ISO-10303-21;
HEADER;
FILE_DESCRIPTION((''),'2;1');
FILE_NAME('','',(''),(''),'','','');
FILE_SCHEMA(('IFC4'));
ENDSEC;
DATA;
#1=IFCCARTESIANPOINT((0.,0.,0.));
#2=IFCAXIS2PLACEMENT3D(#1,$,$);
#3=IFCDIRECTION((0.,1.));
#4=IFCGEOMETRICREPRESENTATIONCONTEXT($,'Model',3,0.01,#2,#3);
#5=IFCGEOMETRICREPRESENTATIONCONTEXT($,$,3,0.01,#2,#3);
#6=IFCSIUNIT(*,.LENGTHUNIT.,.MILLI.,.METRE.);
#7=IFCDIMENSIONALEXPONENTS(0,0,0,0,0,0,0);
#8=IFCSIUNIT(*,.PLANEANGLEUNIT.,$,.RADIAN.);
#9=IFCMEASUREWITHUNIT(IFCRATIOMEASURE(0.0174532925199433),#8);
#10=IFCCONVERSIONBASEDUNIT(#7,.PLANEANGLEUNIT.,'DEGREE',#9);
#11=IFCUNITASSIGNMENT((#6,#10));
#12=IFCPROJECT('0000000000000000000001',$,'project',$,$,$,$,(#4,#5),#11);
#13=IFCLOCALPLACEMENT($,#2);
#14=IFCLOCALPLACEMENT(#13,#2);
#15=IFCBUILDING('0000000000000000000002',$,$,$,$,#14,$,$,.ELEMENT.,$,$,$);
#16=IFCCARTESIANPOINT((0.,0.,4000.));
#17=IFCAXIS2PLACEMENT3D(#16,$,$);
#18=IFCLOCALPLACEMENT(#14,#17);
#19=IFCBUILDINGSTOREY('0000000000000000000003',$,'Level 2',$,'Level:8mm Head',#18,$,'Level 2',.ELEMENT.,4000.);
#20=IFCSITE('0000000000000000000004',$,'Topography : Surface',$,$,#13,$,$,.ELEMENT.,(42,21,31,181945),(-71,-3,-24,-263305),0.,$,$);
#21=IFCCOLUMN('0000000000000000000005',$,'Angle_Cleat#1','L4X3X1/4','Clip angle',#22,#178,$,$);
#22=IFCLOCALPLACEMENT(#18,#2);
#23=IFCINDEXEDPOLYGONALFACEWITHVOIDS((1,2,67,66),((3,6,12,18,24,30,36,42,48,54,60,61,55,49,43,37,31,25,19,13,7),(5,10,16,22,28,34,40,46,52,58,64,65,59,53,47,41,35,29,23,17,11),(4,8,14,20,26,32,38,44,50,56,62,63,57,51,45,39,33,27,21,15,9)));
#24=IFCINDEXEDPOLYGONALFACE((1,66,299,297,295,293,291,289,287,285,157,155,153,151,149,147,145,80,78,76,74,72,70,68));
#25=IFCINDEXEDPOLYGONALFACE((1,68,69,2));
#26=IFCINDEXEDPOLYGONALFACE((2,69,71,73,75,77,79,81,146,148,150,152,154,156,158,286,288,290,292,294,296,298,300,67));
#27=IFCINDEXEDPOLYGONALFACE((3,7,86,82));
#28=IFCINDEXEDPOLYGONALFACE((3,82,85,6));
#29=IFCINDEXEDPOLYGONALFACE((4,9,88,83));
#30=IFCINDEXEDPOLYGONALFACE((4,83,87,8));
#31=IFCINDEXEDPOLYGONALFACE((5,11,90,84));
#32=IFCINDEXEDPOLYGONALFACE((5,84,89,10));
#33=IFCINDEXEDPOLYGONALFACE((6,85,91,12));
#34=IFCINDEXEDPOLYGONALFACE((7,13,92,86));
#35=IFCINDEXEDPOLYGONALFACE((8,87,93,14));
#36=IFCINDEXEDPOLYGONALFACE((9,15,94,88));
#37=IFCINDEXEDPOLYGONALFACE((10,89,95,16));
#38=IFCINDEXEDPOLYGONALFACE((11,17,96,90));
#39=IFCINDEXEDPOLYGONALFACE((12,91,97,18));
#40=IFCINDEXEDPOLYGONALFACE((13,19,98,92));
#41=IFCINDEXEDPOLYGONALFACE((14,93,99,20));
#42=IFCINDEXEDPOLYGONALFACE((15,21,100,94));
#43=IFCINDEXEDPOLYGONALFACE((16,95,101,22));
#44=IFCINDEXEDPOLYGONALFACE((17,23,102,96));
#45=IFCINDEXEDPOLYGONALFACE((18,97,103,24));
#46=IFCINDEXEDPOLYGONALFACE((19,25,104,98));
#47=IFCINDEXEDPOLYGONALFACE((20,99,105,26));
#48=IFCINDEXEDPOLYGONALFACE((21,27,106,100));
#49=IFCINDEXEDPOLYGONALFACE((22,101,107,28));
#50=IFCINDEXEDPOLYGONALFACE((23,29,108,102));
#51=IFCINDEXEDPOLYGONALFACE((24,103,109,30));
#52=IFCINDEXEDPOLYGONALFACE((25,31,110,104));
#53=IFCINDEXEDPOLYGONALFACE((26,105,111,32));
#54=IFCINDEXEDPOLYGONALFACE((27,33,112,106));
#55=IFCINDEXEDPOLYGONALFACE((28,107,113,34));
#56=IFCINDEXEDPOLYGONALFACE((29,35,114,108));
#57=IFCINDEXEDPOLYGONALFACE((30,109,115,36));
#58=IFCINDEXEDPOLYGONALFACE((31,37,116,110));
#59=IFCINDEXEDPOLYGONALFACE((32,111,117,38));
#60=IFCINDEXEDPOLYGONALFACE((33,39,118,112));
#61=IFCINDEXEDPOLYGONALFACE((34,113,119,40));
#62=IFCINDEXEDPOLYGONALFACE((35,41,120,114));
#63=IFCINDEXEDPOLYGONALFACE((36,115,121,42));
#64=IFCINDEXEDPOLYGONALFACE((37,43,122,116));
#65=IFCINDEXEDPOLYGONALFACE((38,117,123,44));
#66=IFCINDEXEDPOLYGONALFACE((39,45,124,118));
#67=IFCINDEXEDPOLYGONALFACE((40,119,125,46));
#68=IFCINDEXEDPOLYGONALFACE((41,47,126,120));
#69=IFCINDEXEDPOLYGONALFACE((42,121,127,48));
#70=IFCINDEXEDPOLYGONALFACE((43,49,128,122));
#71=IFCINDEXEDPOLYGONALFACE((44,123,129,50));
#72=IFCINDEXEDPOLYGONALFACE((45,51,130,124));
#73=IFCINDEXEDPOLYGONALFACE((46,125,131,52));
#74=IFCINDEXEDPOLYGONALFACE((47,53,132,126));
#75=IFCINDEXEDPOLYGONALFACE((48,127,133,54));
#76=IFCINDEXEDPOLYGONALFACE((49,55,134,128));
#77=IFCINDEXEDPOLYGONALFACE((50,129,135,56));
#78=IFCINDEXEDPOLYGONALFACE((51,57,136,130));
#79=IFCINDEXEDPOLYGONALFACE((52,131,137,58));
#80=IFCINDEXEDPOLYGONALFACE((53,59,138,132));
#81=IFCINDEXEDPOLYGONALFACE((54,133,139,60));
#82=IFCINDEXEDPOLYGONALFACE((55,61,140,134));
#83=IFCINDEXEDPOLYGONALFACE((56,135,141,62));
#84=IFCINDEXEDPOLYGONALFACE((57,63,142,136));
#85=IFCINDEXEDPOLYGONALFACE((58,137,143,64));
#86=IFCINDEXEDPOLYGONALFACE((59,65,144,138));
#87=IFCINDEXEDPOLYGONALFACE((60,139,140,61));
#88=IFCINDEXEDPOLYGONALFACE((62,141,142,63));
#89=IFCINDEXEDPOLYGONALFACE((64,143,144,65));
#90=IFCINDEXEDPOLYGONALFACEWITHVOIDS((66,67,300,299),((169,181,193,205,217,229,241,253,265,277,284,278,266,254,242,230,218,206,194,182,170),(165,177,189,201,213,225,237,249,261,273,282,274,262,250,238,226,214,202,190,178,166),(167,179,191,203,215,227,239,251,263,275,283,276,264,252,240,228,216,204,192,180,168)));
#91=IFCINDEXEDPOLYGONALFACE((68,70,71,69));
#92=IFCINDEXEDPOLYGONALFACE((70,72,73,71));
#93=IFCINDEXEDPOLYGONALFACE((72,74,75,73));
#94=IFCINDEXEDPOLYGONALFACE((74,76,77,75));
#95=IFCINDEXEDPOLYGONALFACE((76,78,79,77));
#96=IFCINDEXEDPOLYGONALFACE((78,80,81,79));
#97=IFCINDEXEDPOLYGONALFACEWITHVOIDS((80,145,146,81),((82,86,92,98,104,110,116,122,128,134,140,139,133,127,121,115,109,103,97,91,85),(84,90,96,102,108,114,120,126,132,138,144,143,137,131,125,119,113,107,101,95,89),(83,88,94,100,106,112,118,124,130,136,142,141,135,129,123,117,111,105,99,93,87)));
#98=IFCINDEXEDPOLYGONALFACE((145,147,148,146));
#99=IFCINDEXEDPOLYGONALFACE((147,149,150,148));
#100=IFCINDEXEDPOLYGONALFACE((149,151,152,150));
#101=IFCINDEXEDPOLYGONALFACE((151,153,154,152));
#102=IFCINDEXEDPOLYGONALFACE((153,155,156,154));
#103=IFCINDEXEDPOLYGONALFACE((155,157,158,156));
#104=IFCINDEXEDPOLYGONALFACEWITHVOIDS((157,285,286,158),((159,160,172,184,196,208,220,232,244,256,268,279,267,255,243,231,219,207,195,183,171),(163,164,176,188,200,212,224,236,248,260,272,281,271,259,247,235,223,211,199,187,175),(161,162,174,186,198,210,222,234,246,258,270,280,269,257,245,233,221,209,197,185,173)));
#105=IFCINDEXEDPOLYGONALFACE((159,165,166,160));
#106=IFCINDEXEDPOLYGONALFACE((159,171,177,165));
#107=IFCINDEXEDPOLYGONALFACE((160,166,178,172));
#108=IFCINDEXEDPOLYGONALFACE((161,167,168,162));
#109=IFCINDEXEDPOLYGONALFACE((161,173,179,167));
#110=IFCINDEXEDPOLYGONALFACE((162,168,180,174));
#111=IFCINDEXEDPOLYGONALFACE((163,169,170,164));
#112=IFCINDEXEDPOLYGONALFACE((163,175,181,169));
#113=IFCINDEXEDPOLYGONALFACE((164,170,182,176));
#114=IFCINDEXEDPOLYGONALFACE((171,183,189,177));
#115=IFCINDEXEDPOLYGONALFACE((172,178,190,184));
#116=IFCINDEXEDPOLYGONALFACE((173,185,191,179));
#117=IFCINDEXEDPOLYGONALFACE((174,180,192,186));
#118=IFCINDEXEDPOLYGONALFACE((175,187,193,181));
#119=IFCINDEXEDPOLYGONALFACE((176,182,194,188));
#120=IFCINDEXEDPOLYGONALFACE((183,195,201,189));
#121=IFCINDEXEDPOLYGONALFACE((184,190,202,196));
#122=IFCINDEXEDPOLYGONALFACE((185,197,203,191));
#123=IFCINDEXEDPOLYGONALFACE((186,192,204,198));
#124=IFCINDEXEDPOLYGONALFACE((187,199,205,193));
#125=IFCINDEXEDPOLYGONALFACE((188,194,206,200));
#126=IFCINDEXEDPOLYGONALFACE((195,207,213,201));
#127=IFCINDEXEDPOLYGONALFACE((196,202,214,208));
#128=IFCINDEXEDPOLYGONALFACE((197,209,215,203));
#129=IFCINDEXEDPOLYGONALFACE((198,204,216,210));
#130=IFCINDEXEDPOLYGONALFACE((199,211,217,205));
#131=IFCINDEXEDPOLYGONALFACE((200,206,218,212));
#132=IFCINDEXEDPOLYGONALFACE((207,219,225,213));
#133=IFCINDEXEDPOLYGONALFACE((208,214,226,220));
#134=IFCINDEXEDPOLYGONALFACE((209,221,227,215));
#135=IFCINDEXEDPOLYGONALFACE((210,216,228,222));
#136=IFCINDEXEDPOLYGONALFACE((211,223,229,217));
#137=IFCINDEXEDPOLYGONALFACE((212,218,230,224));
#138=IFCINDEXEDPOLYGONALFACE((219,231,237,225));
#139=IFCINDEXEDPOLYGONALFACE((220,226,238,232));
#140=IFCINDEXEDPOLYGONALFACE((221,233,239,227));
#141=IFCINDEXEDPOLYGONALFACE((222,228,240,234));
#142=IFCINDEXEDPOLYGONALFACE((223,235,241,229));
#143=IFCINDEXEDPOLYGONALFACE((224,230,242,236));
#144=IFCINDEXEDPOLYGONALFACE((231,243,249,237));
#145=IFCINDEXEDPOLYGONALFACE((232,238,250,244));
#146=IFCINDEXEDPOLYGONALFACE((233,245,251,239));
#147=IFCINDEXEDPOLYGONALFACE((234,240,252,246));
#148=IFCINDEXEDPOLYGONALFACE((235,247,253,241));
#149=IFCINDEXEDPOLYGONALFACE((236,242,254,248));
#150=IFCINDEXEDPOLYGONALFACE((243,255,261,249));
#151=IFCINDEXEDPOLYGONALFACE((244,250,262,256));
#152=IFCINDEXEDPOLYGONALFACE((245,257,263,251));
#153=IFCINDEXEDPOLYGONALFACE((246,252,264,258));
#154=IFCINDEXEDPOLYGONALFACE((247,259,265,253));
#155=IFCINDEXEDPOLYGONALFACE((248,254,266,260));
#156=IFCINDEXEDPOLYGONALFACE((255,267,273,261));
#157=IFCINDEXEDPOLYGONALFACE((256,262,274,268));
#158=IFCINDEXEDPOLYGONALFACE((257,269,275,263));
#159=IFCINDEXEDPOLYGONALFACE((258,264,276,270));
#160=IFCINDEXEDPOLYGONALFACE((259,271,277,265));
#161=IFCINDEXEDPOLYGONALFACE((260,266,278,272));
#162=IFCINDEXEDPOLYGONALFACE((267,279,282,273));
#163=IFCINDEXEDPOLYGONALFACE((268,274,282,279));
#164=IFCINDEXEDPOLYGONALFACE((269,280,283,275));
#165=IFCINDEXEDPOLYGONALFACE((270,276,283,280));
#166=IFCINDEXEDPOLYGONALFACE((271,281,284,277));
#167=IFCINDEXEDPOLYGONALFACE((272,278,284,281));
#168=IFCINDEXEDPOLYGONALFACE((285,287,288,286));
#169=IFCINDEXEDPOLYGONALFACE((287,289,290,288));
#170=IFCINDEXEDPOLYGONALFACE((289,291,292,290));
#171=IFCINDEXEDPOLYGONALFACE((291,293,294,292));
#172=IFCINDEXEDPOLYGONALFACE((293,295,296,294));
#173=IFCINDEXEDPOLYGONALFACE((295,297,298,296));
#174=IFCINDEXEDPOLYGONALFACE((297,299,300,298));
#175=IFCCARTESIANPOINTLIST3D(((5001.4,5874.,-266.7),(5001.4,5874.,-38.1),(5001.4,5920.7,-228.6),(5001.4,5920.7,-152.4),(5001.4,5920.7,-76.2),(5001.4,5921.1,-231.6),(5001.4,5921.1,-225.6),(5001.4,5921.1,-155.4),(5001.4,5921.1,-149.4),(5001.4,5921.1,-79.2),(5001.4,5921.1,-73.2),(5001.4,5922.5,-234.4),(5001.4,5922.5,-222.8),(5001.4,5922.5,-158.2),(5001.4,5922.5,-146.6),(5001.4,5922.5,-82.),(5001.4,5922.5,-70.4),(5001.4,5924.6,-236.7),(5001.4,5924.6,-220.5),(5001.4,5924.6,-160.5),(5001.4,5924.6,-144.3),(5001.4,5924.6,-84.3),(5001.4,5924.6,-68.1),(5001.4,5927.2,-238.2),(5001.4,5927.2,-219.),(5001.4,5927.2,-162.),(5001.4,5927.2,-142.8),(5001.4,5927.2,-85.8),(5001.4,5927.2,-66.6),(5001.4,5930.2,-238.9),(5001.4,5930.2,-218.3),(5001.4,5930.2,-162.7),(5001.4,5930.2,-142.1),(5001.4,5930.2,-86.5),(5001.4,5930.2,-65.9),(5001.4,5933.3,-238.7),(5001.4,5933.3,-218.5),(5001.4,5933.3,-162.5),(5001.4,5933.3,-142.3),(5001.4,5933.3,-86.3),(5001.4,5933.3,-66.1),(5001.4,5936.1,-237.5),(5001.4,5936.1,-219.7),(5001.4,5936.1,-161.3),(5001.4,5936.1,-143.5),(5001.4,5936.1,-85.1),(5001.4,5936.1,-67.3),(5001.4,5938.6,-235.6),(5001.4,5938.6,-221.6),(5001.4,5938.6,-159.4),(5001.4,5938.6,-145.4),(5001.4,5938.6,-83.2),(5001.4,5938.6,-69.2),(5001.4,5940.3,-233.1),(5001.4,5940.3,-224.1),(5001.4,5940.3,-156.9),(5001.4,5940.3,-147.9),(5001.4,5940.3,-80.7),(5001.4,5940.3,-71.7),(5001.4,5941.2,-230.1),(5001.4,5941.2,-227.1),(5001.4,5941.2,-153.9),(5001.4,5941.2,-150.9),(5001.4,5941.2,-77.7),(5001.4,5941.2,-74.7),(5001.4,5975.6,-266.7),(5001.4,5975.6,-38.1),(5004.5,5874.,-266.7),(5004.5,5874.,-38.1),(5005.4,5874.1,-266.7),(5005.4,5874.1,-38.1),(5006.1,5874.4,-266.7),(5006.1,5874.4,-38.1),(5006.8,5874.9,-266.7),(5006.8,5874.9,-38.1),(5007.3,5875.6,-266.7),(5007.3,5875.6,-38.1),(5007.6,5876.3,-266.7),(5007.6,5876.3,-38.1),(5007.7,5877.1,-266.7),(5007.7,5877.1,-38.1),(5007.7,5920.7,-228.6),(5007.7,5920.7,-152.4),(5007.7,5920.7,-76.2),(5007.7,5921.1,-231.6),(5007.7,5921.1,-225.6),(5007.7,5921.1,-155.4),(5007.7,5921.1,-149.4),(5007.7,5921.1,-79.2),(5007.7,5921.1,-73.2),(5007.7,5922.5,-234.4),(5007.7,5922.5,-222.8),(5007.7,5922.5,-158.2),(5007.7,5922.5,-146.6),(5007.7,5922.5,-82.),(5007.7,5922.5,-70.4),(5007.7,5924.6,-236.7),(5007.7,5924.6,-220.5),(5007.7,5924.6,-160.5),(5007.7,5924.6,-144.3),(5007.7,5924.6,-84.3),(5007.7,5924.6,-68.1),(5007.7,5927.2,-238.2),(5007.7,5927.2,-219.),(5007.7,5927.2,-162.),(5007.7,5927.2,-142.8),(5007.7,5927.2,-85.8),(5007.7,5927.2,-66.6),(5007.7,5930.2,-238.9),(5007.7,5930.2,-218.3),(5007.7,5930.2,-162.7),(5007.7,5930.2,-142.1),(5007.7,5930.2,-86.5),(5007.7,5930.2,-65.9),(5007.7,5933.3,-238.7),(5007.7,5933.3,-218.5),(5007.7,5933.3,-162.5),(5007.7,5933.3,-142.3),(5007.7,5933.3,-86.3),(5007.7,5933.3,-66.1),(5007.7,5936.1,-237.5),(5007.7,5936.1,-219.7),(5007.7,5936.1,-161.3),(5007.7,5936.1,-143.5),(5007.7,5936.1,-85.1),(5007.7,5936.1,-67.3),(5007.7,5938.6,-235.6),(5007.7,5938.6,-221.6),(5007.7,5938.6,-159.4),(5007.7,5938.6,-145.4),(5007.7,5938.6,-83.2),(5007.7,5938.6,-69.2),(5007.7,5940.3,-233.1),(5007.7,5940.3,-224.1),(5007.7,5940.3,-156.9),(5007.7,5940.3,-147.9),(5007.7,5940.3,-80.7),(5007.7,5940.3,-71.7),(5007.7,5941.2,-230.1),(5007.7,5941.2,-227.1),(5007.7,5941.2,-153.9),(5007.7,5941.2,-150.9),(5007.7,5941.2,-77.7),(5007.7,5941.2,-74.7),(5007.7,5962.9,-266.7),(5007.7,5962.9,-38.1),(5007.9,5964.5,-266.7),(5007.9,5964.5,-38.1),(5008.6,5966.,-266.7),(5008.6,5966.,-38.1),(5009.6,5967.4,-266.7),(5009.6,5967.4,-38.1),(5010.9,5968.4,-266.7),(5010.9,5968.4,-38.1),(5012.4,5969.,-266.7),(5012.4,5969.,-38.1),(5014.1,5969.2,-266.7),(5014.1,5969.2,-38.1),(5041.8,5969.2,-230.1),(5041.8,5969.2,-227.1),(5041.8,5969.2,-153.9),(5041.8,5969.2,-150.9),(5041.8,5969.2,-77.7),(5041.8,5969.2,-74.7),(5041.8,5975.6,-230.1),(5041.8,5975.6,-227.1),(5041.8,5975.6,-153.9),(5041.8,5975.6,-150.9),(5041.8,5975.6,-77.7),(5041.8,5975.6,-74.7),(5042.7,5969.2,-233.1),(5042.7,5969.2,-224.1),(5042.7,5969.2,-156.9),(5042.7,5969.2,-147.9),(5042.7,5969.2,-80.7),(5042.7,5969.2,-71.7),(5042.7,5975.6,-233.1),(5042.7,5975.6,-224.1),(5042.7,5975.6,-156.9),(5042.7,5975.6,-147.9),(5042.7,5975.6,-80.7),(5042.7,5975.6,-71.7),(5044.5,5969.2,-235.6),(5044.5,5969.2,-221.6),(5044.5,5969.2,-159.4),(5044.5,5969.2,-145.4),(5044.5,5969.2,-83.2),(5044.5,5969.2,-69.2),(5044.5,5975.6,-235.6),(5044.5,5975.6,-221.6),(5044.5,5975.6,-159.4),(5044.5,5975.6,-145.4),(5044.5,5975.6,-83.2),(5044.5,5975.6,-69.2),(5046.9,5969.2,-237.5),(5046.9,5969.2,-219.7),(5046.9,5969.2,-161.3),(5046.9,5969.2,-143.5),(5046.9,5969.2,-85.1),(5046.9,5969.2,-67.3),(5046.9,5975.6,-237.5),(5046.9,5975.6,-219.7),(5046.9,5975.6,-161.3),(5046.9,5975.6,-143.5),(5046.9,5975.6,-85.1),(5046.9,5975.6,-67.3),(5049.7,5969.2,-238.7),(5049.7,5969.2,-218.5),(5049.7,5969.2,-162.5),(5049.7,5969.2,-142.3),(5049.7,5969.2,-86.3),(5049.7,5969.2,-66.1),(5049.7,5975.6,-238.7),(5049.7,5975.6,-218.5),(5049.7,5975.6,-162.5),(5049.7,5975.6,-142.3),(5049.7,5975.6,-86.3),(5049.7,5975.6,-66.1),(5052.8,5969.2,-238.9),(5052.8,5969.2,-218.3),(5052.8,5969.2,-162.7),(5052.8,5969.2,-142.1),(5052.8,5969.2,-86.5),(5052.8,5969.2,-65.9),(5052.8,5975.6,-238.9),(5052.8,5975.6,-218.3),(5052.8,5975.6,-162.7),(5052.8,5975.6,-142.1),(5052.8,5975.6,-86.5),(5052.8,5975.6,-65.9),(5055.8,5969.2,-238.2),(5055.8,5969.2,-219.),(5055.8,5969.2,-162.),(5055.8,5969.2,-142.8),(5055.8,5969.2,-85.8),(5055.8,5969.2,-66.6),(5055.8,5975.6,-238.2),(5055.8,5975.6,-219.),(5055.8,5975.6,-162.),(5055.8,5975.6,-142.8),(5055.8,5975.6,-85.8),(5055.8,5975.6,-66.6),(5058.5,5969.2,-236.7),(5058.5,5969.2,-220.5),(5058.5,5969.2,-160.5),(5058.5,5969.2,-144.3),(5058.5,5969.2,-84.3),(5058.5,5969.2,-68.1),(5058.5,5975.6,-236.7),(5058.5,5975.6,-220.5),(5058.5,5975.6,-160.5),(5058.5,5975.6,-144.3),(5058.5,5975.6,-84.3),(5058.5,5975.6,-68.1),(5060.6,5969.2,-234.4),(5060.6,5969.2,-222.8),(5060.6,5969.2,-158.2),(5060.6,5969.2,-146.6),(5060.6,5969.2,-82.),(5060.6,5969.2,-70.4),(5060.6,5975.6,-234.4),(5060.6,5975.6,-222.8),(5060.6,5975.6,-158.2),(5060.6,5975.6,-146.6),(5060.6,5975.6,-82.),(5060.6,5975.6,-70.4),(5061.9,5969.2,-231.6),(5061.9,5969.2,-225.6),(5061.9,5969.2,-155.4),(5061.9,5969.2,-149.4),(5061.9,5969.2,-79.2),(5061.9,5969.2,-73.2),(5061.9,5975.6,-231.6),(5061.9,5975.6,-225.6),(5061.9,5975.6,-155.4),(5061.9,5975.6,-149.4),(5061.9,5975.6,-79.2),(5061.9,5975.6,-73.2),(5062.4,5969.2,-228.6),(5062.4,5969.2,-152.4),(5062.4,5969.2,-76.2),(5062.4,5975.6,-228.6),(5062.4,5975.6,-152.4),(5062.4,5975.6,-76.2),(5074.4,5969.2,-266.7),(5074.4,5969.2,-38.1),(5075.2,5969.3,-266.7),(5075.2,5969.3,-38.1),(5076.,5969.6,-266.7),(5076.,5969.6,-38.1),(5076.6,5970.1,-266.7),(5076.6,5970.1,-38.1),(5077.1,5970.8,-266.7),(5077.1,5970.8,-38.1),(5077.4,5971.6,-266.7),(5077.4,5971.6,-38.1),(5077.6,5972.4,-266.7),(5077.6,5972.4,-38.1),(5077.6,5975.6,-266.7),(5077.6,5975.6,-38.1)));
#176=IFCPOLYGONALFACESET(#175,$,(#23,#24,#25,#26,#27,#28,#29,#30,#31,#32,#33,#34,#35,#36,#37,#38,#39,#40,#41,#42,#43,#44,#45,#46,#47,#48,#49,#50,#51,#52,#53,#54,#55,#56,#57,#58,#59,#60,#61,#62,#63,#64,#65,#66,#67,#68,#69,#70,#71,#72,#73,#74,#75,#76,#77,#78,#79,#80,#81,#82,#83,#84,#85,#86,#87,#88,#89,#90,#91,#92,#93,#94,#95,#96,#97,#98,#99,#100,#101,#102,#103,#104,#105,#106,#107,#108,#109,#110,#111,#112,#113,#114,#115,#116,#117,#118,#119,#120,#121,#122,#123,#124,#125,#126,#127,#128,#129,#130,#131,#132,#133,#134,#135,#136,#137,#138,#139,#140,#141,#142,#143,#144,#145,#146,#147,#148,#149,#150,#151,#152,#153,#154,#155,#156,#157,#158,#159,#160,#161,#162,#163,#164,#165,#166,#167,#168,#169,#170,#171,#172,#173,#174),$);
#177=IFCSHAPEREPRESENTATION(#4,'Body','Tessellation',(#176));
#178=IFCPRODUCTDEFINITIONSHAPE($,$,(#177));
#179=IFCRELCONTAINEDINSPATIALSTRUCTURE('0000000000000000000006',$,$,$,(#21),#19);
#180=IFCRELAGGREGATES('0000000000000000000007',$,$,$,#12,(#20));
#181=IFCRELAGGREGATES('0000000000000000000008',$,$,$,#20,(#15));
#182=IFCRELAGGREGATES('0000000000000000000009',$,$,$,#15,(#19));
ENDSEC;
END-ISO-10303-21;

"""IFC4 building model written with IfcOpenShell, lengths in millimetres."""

from ifc_helpers import new_model, entity, si_unit, converted_unit, direction, frame, frame_2d, origin, origin_2d_with_axis, place, context, project, spatial, circle, l_section, extrude, element, save


model = new_model("IFC4")

# Units and contexts
model_context = context("Model", 3, precision=0.01, world=origin(), true_north=direction((0.0, 1.0)))
context_of_model = context(None, 3, precision=0.01, world=origin(), true_north=direction((0.0, 1.0)))
ifc_project = project(units=[si_unit("LENGTHUNIT", "METRE", prefix="MILLI"), converted_unit("PLANEANGLEUNIT", "DEGREE", entity("IfcRatioMeasure", 0.0174532925199433), si_unit("PLANEANGLEUNIT", "RADIAN"), dimensions=[0, 0, 0, 0, 0, 0, 0])], contexts=[model_context, context_of_model])

# Site, building, storey
site_placement = place(None, origin())
site = spatial("IfcSite", under=ifc_project, at=site_placement, Name="Topography : Surface", CompositionType="ELEMENT", RefLatitude=(42, 21, 31, 181945), RefLongitude=(-71, -3, -24, -263305), RefElevation=0.0)
building_placement = place(site_placement, origin())
building = spatial("IfcBuilding", under=site, at=building_placement, CompositionType="ELEMENT")
storey_placement = place(building_placement, frame((0.0, 0.0, 4000.0)))
storey = spatial("IfcBuildingStorey", under=building, at=storey_placement, Name="Level 2", ObjectType="Level:8mm Head", LongName="Level 2", CompositionType="ELEMENT", Elevation=4000.0)

# Column, openings
column_1_placement = place(storey_placement, frame((5019.6, 5944.4, -266.7), z_axis=(0.0, 0.0, -1.0), x_axis=(1.0, 0.0, 0.0)))
column_1 = element("IfcColumn", 1, at=column_1_placement, inside=storey, Name="Angle_Cleat#1", Description="L4X3X1/4", ObjectType="Clip angle", context=model_context, shape_type="SweptSolid", body=[
    extrude(l_section(Depth=101.6, Width=76.2, Thickness=6.3, FilletRadius=6.3, EdgeRadius=3.2, at=frame_2d((19.8, 19.7))), origin(), (0.0, 0.0, -1.0), 228.6),
])
opening_1_placement = place(column_1_placement, frame((32.4, -31.5, -114.3), z_axis=(0.0, 1.0, 0.0), x_axis=(1.0, 0.0, 0.0)))
element("IfcOpeningElement", 2, at=opening_1_placement, cuts=column_1, ObjectType="Opening", context=model_context, shape_type="SweptSolid", body=[
    extrude(circle(Radius=10.3, at=origin_2d_with_axis()), origin(), (0.0, 0.0, 1.0), 7.3),
])
opening_2_placement = place(column_1_placement, frame((32.4, -31.5, -114.3), z_axis=(0.0, 1.0, 0.0), x_axis=(1.0, 0.0, 0.0)))
element("IfcOpeningElement", 3, at=opening_2_placement, cuts=column_1, ObjectType="Opening", context=model_context, shape_type="SweptSolid", body=[
    extrude(circle(Radius=10.3, at=frame_2d((0.0, 76.2), x_axis=(1.0, 0.0))), origin(), (0.0, 0.0, 1.0), 7.3),
])
opening_3_placement = place(column_1_placement, frame((32.4, -31.5, -114.3), z_axis=(0.0, 1.0, 0.0), x_axis=(1.0, 0.0, 0.0)))
element("IfcOpeningElement", 4, at=opening_3_placement, cuts=column_1, ObjectType="Opening", context=model_context, shape_type="SweptSolid", body=[
    extrude(circle(Radius=10.3, at=frame_2d((0.0, -76.2), x_axis=(1.0, 0.0))), origin(), (0.0, 0.0, 1.0), 7.3),
])
opening_4_placement = place(column_1_placement, frame((-18.9, 13.5, -114.3), z_axis=(1.0, 0.0, 0.0), x_axis=(0.0, 1.0, 0.0)))
element("IfcOpeningElement", 5, at=opening_4_placement, cuts=column_1, ObjectType="Opening", context=model_context, shape_type="SweptSolid", body=[
    extrude(circle(Radius=10.3, at=origin_2d_with_axis()), origin(), (0.0, 0.0, 1.0), 7.3),
])
opening_5_placement = place(column_1_placement, frame((-18.9, 13.5, -114.3), z_axis=(1.0, 0.0, 0.0), x_axis=(0.0, 1.0, 0.0)))
element("IfcOpeningElement", 6, at=opening_5_placement, cuts=column_1, ObjectType="Opening", context=model_context, shape_type="SweptSolid", body=[
    extrude(circle(Radius=10.3, at=frame_2d((0.0, 76.2), x_axis=(1.0, 0.0))), origin(), (0.0, 0.0, 1.0), 7.3),
])
opening_6_placement = place(column_1_placement, frame((-18.9, 13.5, -114.3), z_axis=(1.0, 0.0, 0.0), x_axis=(0.0, 1.0, 0.0)))
element("IfcOpeningElement", 7, at=opening_6_placement, cuts=column_1, ObjectType="Opening", context=model_context, shape_type="SweptSolid", body=[
    extrude(circle(Radius=10.3, at=frame_2d((0.0, -76.2), x_axis=(1.0, 0.0))), origin(), (0.0, 0.0, 1.0), 7.3),
])

save(model, "model.ifc")
